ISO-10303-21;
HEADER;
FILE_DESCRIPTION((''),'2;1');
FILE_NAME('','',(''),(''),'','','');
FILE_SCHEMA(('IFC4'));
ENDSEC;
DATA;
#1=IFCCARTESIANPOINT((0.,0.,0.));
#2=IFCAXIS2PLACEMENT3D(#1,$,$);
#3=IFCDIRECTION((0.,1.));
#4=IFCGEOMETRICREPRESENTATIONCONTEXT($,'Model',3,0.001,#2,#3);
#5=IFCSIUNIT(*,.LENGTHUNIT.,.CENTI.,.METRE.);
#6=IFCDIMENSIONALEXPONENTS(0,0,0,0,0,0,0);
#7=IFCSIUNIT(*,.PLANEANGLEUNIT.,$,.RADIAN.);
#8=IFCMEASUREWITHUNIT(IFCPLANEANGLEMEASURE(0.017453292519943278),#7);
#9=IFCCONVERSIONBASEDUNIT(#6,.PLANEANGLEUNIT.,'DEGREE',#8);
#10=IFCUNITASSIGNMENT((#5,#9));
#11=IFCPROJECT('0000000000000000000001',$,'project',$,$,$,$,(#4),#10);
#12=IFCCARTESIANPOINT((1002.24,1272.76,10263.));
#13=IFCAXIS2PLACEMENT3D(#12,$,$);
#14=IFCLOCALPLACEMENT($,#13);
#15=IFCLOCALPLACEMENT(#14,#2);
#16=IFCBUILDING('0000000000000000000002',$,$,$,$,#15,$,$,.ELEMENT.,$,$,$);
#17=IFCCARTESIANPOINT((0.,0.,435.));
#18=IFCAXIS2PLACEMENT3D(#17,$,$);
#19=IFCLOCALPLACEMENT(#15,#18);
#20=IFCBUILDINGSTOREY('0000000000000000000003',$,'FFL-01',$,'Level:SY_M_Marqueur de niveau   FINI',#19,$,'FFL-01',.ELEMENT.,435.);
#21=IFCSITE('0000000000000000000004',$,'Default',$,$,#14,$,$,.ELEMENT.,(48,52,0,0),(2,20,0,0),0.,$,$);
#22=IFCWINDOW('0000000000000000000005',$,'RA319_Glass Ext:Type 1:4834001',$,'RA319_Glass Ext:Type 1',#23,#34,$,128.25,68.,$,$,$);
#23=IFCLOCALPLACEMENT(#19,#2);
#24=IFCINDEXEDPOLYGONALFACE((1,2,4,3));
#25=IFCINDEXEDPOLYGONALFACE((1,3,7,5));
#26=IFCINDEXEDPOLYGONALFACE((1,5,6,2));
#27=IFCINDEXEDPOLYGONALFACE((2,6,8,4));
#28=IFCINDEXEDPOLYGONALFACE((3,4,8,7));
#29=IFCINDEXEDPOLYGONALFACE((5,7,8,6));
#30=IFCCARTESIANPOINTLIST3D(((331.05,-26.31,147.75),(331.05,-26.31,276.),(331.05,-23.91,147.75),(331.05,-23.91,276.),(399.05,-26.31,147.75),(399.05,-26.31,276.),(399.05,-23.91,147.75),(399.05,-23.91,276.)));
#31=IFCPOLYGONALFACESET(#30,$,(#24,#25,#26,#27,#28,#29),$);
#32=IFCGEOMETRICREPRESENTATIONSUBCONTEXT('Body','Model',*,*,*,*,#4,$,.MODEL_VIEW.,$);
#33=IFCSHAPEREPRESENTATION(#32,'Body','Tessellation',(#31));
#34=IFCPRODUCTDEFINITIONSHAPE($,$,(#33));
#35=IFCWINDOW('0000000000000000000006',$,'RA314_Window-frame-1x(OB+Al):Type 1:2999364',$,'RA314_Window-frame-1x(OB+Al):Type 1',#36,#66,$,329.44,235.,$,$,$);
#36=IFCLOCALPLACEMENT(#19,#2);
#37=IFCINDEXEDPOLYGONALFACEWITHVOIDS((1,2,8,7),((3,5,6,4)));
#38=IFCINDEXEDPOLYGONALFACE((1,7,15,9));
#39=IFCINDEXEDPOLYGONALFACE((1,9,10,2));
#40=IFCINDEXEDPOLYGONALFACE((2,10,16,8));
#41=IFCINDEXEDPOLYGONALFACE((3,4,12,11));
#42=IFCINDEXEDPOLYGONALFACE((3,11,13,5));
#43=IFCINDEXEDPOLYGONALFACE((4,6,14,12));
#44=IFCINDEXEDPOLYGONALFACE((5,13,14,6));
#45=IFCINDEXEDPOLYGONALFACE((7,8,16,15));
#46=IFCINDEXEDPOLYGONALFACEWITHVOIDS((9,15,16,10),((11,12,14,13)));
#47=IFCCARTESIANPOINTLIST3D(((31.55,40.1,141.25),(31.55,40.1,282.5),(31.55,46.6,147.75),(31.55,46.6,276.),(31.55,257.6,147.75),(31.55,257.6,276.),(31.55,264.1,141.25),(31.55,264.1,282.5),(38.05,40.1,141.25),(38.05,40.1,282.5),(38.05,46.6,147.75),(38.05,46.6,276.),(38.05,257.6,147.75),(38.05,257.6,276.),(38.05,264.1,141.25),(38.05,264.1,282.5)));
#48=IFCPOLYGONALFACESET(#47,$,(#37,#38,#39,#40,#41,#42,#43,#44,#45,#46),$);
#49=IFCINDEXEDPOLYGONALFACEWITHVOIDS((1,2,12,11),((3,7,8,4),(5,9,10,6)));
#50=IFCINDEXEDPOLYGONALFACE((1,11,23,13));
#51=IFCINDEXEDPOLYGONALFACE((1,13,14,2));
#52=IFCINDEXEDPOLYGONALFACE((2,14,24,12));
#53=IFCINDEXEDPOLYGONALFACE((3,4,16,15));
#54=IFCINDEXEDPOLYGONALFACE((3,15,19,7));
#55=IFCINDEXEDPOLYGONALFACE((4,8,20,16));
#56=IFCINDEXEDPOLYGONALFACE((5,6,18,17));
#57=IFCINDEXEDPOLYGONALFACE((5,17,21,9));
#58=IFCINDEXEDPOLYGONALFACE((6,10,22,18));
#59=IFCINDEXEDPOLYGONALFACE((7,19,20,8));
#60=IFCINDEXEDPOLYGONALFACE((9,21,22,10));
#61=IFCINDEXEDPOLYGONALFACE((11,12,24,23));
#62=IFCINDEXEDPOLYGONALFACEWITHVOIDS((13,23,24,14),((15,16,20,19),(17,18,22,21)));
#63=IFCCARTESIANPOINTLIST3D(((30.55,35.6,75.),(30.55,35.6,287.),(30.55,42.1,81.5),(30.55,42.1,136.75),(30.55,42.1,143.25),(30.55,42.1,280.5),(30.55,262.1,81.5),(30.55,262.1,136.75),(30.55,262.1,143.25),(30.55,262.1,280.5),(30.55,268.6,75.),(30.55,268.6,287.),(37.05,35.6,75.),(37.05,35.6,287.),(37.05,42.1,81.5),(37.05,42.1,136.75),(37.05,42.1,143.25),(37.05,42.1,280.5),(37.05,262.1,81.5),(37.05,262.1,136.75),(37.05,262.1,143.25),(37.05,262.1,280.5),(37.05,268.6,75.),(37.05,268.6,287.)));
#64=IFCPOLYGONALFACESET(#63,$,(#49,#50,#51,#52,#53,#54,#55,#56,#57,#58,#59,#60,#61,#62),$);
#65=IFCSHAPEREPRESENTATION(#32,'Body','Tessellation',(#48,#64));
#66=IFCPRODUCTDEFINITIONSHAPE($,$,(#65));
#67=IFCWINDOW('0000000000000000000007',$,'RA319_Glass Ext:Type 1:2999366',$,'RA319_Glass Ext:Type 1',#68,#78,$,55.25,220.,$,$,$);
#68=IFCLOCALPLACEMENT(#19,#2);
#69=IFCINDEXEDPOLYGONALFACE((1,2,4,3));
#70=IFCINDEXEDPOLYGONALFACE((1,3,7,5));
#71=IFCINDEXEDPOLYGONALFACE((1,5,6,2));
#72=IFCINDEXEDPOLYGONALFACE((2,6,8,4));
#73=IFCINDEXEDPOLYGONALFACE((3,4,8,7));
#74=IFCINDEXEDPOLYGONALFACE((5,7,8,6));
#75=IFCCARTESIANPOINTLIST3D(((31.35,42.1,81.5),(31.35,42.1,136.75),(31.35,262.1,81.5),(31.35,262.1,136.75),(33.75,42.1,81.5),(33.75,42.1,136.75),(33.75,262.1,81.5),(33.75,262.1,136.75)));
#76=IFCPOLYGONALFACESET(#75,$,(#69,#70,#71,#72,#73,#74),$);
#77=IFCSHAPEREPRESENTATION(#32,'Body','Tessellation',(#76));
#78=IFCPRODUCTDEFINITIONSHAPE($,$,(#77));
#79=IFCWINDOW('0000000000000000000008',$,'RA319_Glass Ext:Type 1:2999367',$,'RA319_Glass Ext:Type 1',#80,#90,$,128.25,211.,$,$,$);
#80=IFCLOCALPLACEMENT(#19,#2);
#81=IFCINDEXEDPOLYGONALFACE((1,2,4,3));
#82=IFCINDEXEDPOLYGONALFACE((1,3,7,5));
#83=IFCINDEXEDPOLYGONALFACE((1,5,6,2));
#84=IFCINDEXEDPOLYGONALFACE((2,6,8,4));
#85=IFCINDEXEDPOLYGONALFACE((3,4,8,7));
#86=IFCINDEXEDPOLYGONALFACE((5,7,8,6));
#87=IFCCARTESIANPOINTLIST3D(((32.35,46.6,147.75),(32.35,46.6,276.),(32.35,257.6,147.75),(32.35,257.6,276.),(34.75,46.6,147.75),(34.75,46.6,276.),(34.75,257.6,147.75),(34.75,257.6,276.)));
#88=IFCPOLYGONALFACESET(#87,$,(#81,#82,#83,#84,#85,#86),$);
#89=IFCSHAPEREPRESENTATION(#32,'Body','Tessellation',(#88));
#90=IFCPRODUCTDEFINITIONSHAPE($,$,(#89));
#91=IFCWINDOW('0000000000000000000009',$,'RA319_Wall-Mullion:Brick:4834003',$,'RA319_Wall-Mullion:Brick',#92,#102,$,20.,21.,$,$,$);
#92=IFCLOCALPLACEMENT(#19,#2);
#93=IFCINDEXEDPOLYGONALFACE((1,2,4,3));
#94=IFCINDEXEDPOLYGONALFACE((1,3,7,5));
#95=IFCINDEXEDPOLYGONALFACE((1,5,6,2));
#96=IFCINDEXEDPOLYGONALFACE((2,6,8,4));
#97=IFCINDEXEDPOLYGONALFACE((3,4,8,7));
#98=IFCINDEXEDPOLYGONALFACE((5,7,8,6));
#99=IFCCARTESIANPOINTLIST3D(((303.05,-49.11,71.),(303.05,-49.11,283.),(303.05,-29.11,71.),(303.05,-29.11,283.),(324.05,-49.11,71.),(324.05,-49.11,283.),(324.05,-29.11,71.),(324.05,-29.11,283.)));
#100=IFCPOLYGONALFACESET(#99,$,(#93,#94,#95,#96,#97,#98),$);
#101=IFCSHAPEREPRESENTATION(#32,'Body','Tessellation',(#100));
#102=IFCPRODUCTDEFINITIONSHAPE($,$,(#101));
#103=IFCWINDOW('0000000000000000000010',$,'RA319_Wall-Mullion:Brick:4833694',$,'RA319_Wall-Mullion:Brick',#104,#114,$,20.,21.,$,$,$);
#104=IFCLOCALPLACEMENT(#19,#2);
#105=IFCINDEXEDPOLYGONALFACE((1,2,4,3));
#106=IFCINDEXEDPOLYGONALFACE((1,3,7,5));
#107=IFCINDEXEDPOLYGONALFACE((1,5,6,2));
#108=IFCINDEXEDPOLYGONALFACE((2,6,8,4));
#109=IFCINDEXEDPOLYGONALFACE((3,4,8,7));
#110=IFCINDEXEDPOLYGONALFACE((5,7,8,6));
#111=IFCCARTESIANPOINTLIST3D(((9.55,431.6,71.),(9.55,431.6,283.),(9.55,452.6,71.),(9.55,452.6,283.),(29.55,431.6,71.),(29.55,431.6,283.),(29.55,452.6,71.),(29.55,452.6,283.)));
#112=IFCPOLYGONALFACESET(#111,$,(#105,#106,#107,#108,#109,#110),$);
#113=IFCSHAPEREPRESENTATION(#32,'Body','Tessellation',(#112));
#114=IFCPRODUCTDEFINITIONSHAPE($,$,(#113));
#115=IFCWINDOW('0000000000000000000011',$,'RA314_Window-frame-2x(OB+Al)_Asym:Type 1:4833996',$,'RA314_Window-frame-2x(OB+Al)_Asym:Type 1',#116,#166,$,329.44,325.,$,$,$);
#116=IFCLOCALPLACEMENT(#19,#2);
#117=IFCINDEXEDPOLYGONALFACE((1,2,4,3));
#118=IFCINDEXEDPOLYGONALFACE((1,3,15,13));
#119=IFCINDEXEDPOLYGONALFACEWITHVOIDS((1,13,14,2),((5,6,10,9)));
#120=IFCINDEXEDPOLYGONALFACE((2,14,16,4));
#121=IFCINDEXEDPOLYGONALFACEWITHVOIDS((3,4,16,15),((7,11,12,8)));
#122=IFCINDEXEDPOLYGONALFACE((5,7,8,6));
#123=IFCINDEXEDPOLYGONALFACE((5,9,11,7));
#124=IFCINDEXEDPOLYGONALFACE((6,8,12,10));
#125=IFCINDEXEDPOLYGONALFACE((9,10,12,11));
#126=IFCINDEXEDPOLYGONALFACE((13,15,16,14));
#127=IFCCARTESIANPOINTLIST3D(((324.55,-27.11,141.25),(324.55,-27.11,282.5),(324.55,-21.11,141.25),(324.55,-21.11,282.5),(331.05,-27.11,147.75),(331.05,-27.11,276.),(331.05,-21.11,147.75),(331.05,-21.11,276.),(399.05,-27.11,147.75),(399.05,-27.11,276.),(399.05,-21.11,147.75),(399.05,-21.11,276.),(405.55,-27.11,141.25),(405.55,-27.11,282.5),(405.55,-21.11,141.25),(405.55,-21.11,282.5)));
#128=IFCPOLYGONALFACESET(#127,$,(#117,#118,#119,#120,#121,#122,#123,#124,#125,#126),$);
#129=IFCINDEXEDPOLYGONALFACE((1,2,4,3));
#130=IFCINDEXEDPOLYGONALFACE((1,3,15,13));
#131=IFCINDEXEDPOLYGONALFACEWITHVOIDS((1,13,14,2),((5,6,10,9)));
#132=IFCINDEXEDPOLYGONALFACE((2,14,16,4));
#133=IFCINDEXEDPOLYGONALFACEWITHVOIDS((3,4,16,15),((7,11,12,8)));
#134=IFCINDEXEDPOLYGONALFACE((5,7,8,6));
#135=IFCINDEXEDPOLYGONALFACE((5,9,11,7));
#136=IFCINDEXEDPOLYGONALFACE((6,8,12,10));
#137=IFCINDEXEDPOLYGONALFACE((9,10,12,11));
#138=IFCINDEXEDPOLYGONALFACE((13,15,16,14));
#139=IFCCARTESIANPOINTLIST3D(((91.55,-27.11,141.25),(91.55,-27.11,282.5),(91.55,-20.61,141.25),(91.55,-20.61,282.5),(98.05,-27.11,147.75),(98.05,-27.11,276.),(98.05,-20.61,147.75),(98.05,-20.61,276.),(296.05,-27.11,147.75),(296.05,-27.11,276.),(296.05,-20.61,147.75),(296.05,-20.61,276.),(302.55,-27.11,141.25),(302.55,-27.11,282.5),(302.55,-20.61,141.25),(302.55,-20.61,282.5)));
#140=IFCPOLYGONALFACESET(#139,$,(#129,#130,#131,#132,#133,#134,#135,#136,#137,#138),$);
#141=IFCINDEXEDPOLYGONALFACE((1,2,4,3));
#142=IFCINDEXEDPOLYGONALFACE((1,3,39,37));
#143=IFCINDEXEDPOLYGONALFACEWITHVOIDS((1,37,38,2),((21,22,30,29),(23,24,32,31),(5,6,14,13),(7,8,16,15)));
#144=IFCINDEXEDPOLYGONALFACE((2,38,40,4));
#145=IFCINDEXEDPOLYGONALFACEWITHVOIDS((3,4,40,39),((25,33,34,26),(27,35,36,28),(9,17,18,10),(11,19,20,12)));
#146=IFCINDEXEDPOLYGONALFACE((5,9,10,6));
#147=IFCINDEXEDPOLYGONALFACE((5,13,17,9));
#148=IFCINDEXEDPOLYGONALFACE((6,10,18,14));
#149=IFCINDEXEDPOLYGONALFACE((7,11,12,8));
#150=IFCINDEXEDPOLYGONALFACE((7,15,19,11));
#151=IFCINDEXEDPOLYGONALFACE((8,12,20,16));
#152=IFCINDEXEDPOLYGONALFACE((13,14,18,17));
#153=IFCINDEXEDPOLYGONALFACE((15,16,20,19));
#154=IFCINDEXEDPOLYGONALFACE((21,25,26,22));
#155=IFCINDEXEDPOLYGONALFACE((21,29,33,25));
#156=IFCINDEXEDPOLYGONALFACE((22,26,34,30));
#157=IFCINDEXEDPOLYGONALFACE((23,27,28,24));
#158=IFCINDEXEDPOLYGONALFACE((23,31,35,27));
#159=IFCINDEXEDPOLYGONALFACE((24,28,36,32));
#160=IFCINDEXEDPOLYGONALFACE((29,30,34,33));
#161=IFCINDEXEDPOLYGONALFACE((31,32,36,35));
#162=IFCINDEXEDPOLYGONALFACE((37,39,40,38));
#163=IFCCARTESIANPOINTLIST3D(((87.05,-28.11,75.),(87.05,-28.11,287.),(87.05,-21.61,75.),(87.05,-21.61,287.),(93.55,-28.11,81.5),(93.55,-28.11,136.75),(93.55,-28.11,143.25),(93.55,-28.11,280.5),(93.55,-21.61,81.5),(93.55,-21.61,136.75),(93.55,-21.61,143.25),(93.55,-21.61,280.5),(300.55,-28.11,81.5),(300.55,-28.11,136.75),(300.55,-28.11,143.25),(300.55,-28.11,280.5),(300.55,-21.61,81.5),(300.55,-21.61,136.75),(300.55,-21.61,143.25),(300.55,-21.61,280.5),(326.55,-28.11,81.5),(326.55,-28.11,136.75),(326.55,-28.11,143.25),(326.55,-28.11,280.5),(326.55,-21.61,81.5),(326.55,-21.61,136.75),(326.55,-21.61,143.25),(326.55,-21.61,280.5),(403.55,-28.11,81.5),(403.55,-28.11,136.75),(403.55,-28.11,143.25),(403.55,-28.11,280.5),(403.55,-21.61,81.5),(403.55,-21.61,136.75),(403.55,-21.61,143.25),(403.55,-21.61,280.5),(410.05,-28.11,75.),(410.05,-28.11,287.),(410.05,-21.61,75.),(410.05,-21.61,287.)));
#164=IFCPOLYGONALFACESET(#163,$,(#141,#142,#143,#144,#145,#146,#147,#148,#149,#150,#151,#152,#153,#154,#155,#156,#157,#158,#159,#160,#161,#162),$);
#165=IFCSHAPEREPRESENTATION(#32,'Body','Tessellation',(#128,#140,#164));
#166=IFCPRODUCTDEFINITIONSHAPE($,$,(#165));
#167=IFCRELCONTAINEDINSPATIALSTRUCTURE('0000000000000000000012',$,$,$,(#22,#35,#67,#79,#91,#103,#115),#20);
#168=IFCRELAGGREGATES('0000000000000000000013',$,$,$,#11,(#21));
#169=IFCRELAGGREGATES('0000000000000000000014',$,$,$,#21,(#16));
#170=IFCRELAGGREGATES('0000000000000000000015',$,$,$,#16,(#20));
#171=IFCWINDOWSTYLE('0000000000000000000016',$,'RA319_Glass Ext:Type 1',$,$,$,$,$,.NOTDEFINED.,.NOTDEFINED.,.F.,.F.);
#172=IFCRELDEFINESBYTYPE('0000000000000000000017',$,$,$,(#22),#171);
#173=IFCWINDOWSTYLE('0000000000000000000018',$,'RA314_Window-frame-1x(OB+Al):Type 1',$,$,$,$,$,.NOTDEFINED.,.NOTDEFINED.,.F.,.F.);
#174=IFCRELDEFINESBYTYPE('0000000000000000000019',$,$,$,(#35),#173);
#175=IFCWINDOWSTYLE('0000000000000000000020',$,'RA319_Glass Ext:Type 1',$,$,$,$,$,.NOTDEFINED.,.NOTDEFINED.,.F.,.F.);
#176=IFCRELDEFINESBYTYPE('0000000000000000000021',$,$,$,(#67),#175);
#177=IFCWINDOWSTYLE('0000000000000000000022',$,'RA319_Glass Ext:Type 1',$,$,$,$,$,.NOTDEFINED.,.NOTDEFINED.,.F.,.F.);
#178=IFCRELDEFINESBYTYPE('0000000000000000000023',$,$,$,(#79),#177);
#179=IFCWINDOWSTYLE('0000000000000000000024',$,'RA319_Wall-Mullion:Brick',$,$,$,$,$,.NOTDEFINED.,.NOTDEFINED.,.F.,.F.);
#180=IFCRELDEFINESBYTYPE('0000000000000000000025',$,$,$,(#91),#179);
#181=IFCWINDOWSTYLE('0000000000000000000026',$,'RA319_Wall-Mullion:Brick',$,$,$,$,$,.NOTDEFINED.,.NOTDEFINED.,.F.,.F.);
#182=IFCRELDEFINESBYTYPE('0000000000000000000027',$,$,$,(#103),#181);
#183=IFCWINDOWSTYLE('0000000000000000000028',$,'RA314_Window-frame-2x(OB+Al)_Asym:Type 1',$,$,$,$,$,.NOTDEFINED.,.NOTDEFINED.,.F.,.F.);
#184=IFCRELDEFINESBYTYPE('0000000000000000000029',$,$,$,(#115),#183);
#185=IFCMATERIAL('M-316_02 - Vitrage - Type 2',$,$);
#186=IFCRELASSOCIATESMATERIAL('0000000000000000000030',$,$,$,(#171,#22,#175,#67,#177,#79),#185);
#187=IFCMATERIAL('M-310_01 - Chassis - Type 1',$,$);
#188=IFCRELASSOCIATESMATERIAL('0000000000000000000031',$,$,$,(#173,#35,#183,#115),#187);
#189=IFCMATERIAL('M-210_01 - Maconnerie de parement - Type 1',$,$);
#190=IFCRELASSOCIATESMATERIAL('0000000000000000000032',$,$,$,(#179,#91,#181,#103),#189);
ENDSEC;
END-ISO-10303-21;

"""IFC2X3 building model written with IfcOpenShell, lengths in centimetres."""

from ifc_helpers import new_model, entity, si_unit, converted_unit, direction, frame, frame_2d, origin, origin_2d_with_axis, place, context, subcontext, project, spatial, polyline, rectangle, outline, extrude, source, transform, mapped, material, type_object, type_shapes, element, save


model = new_model("IFC2X3")

# Units and contexts
model_context = context("Model", 3, precision=0.001, world=origin(), true_north=direction((0.0, 1.0)))
body_context = subcontext(model_context, "Body", "Model", "MODEL_VIEW")
ifc_project = project(units=[si_unit("LENGTHUNIT", "METRE", prefix="CENTI"), converted_unit("PLANEANGLEUNIT", "DEGREE", entity("IfcPlaneAngleMeasure", 0.017453292519943278), si_unit("PLANEANGLEUNIT", "RADIAN"), dimensions=[0, 0, 0, 0, 0, 0, 0])], contexts=[model_context])

# Site, building, storey
site_placement = place(None, frame((1002.24, 1272.76, 10263.0)))
site = spatial("IfcSite", under=ifc_project, at=site_placement, Name="Default", CompositionType="ELEMENT", RefLatitude=(48, 52, 0, 0), RefLongitude=(2, 20, 0, 0), RefElevation=0.0)
building_placement = place(site_placement, origin())
building = spatial("IfcBuilding", under=site, at=building_placement, CompositionType="ELEMENT")
storey_placement = place(building_placement, frame((0.0, 0.0, 435.0)))
storey = spatial("IfcBuildingStorey", under=building, at=storey_placement, Name="FFL-01", ObjectType="Level:SY_M_Marqueur de niveau   FINI", LongName="FFL-01", CompositionType="ELEMENT", Elevation=435.0)

# Windows
ifc_material_1 = material(Name="M-310_01 - Chassis - Type 1")
ifc_material_2 = material(Name="M-316_02 - Vitrage - Type 2")
window_style_1 = type_object("IfcWindowStyle", Name="RA319_Glass Ext:Type 1", ConstructionType="NOTDEFINED", OperationType="NOTDEFINED", ParameterTakesPrecedence=False, Sizeable=False, material=ifc_material_2)
shared_shape_1 = source(origin(), body_context, "Body", "SweptSolid", [
    extrude(rectangle(XDim=68.0, YDim=128.25, at=frame_2d((0.0, 0.0), x_axis=(1.0, 0.0))), frame((0.0, 0.0, 0.0), z_axis=(0.0, 0.0, 1.0), x_axis=(-1.0, 0.0, 0.0)), (0.0, 0.0, 1.0), 2.4),
])
type_shapes(window_style_1, [shared_shape_1])
window_1_placement = place(storey_placement, frame((365.05, -26.31, 211.88), z_axis=(0.0, 1.0, 0.0), x_axis=(-1.0, 0.0, 0.0)))
element("IfcWindow", 1, at=window_1_placement, inside=storey, type_object=window_style_1, material=ifc_material_2, Name="RA319_Glass Ext:Type 1:4834001", ObjectType="RA319_Glass Ext:Type 1", OverallHeight=128.25, OverallWidth=68.0, context=body_context, shape_type="MappedRepresentation", body=[
    mapped(shared_shape_1, transform((0.0, 0.0, 0.0), scale=1.0)),
])
window_style_2 = type_object("IfcWindowStyle", Name="RA314_Window-frame-1x(OB+Al):Type 1", ConstructionType="NOTDEFINED", OperationType="NOTDEFINED", ParameterTakesPrecedence=False, Sizeable=False, material=ifc_material_1)
shared_shape_2 = source(origin(), body_context, "Body", "SweptSolid", [
    extrude(outline(polyline([(-70.62, -112.0), (70.62, -112.0), (70.62, 112.0), (-70.62, 112.0), (-70.62, -112.0)]), holes=[polyline([(-64.12, -105.5), (-64.12, 105.5), (64.12, 105.5), (64.12, -105.5), (-64.12, -105.5)])]), frame((0.0, 1.0, 136.87), z_axis=(0.0, 1.0, 0.0), x_axis=(0.0, 0.0, -1.0)), (0.0, 0.0, 1.0), 6.5),
    extrude(outline(polyline([(-106.0, -116.5), (106.0, -116.5), (106.0, 116.5), (-106.0, 116.5), (-106.0, -116.5)]), holes=[polyline([(-99.5, -110.0), (-99.5, 110.0), (37.75, 110.0), (37.75, -110.0), (-99.5, -110.0)]), polyline([(44.25, -110.0), (44.25, 110.0), (99.5, 110.0), (99.5, -110.0), (44.25, -110.0)])]), frame((0.0, 0.0, 106.0), z_axis=(0.0, 1.0, 0.0), x_axis=(0.0, 0.0, -1.0)), (0.0, 0.0, 1.0), 6.5),
])
type_shapes(window_style_2, [shared_shape_2])
window_2_placement = place(storey_placement, frame((30.55, 152.1, 75.0), z_axis=(0.0, 0.0, 1.0), x_axis=(0.0, -1.0, 0.0)))
element("IfcWindow", 2, at=window_2_placement, inside=storey, type_object=window_style_2, material=ifc_material_1, Name="RA314_Window-frame-1x(OB+Al):Type 1:2999364", ObjectType="RA314_Window-frame-1x(OB+Al):Type 1", OverallHeight=329.44, OverallWidth=235.0, context=body_context, shape_type="MappedRepresentation", body=[
    mapped(shared_shape_2, transform((0.0, 0.0, 0.0), scale=1.0)),
])
window_style_3 = type_object("IfcWindowStyle", Name="RA319_Glass Ext:Type 1", ConstructionType="NOTDEFINED", OperationType="NOTDEFINED", ParameterTakesPrecedence=False, Sizeable=False, material=ifc_material_2)
shared_shape_3 = source(origin(), body_context, "Body", "SweptSolid", [
    extrude(rectangle(XDim=220.0, YDim=55.25, at=frame_2d((0.0, 0.0), x_axis=(1.0, 0.0))), frame((0.0, 0.0, 0.0), z_axis=(0.0, 0.0, 1.0), x_axis=(-1.0, 0.0, 0.0)), (0.0, 0.0, 1.0), 2.4),
])
type_shapes(window_style_3, [shared_shape_3])
window_3_placement = place(storey_placement, frame((31.35, 152.1, 109.12), z_axis=(1.0, 0.0, 0.0), x_axis=(0.0, 1.0, 0.0)))
element("IfcWindow", 3, at=window_3_placement, inside=storey, type_object=window_style_3, material=ifc_material_2, Name="RA319_Glass Ext:Type 1:2999366", ObjectType="RA319_Glass Ext:Type 1", OverallHeight=55.25, OverallWidth=220.0, context=body_context, shape_type="MappedRepresentation", body=[
    mapped(shared_shape_3, transform((0.0, 0.0, 0.0), scale=1.0)),
])
window_style_4 = type_object("IfcWindowStyle", Name="RA319_Glass Ext:Type 1", ConstructionType="NOTDEFINED", OperationType="NOTDEFINED", ParameterTakesPrecedence=False, Sizeable=False, material=ifc_material_2)
shared_shape_4 = source(origin(), body_context, "Body", "SweptSolid", [
    extrude(rectangle(XDim=211.0, YDim=128.25, at=frame_2d((0.0, 0.0), x_axis=(1.0, 0.0))), frame((0.0, 0.0, 0.0), z_axis=(0.0, 0.0, 1.0), x_axis=(-1.0, 0.0, 0.0)), (0.0, 0.0, 1.0), 2.4),
])
type_shapes(window_style_4, [shared_shape_4])
window_4_placement = place(storey_placement, frame((32.35, 152.1, 211.87), z_axis=(1.0, 0.0, 0.0), x_axis=(0.0, 1.0, 0.0)))
element("IfcWindow", 4, at=window_4_placement, inside=storey, type_object=window_style_4, material=ifc_material_2, Name="RA319_Glass Ext:Type 1:2999367", ObjectType="RA319_Glass Ext:Type 1", OverallHeight=128.25, OverallWidth=211.0, context=body_context, shape_type="MappedRepresentation", body=[
    mapped(shared_shape_4, transform((0.0, 0.0, 0.0), scale=1.0)),
])
ifc_material_3 = material(Name="M-210_01 - Maconnerie de parement - Type 1")
window_style_5 = type_object("IfcWindowStyle", Name="RA319_Wall-Mullion:Brick", ConstructionType="NOTDEFINED", OperationType="NOTDEFINED", ParameterTakesPrecedence=False, Sizeable=False, material=ifc_material_3)
shared_shape_5 = source(origin(), body_context, "Body", "SweptSolid", [
    extrude(rectangle(XDim=21.0, YDim=20.0, at=origin_2d_with_axis()), frame((0.0, 10.0, -4.0), z_axis=(0.0, 0.0, 1.0), x_axis=(-1.0, 0.0, 0.0)), (0.0, 0.0, 1.0), 212.0),
])
type_shapes(window_style_5, [shared_shape_5])
window_5_placement = place(storey_placement, frame((313.55, -29.11, 75.0), z_axis=(0.0, 0.0, 1.0), x_axis=(-1.0, 0.0, 0.0)))
element("IfcWindow", 5, at=window_5_placement, inside=storey, type_object=window_style_5, material=ifc_material_3, Name="RA319_Wall-Mullion:Brick:4834003", ObjectType="RA319_Wall-Mullion:Brick", OverallHeight=20.0, OverallWidth=21.0, context=body_context, shape_type="MappedRepresentation", body=[
    mapped(shared_shape_5, transform((0.0, 0.0, 0.0), scale=1.0)),
])
window_style_6 = type_object("IfcWindowStyle", Name="RA319_Wall-Mullion:Brick", ConstructionType="NOTDEFINED", OperationType="NOTDEFINED", ParameterTakesPrecedence=False, Sizeable=False, material=ifc_material_3)
shared_shape_6 = source(origin(), body_context, "Body", "SweptSolid", [
    extrude(rectangle(XDim=20.0, YDim=21.0, at=origin_2d_with_axis()), frame((0.0, -10.0, -4.0), z_axis=(0.0, 0.0, 1.0), x_axis=(0.0, 1.0, 0.0)), (0.0, 0.0, 1.0), 212.0),
])
type_shapes(window_style_6, [shared_shape_6])
window_6_placement = place(storey_placement, frame((29.55, 442.1, 75.0), z_axis=(0.0, 0.0, 1.0), x_axis=(0.0, -1.0, 0.0)))
element("IfcWindow", 6, at=window_6_placement, inside=storey, type_object=window_style_6, material=ifc_material_3, Name="RA319_Wall-Mullion:Brick:4833694", ObjectType="RA319_Wall-Mullion:Brick", OverallHeight=20.0, OverallWidth=21.0, context=body_context, shape_type="MappedRepresentation", body=[
    mapped(shared_shape_6, transform((0.0, 0.0, 0.0), scale=1.0)),
])
window_style_7 = type_object("IfcWindowStyle", Name="RA314_Window-frame-2x(OB+Al)_Asym:Type 1", ConstructionType="NOTDEFINED", OperationType="NOTDEFINED", ParameterTakesPrecedence=False, Sizeable=False, material=ifc_material_1)
shared_shape_7 = source(origin(), body_context, "Body", "SweptSolid", [
    extrude(outline(polyline([(-70.62, -40.5), (70.62, -40.5), (70.62, 40.5), (-70.62, 40.5), (-70.62, -40.5)]), holes=[polyline([(-64.12, -34.0), (-64.12, 34.0), (64.12, 34.0), (64.12, -34.0), (-64.12, -34.0)])]), frame((116.5, 1.0, 136.87), z_axis=(0.0, 1.0, 0.0), x_axis=(0.0, 0.0, -1.0)), (0.0, 0.0, 1.0), 6.0),
    extrude(outline(polyline([(-70.62, -105.5), (70.62, -105.5), (70.62, 105.5), (-70.62, 105.5), (-70.62, -105.5)]), holes=[polyline([(-64.12, -99.0), (-64.12, 99.0), (64.12, 99.0), (64.12, -99.0), (-64.12, -99.0)])]), frame((-51.5, 1.0, 136.87), z_axis=(0.0, 1.0, 0.0), x_axis=(0.0, 0.0, -1.0)), (0.0, 0.0, 1.0), 6.5),
    extrude(outline(polyline([(-106.0, -161.5), (106.0, -161.5), (106.0, 161.5), (-106.0, 161.5), (-106.0, -161.5)]), holes=[polyline([(44.25, -52.0), (44.25, 155.0), (99.5, 155.0), (99.5, -52.0), (44.25, -52.0)]), polyline([(44.25, -155.0), (44.25, -78.0), (99.5, -78.0), (99.5, -155.0), (44.25, -155.0)]), polyline([(-99.5, -155.0), (-99.5, -78.0), (37.75, -78.0), (37.75, -155.0), (-99.5, -155.0)]), polyline([(-99.5, -52.0), (-99.5, 155.0), (37.75, 155.0), (37.75, -52.0), (-99.5, -52.0)])]), frame((0.0, 0.0, 106.0), z_axis=(0.0, 1.0, 0.0), x_axis=(0.0, 0.0, -1.0)), (0.0, 0.0, 1.0), 6.5),
])
type_shapes(window_style_7, [shared_shape_7])
window_7_placement = place(storey_placement, frame((248.55, -28.11, 75.0)))
element("IfcWindow", 7, at=window_7_placement, inside=storey, type_object=window_style_7, material=ifc_material_1, Name="RA314_Window-frame-2x(OB+Al)_Asym:Type 1:4833996", ObjectType="RA314_Window-frame-2x(OB+Al)_Asym:Type 1", OverallHeight=329.44, OverallWidth=325.0, context=body_context, shape_type="MappedRepresentation", body=[
    mapped(shared_shape_7, transform((0.0, 0.0, 0.0), scale=1.0)),
])

save(model, "model.ifc")
